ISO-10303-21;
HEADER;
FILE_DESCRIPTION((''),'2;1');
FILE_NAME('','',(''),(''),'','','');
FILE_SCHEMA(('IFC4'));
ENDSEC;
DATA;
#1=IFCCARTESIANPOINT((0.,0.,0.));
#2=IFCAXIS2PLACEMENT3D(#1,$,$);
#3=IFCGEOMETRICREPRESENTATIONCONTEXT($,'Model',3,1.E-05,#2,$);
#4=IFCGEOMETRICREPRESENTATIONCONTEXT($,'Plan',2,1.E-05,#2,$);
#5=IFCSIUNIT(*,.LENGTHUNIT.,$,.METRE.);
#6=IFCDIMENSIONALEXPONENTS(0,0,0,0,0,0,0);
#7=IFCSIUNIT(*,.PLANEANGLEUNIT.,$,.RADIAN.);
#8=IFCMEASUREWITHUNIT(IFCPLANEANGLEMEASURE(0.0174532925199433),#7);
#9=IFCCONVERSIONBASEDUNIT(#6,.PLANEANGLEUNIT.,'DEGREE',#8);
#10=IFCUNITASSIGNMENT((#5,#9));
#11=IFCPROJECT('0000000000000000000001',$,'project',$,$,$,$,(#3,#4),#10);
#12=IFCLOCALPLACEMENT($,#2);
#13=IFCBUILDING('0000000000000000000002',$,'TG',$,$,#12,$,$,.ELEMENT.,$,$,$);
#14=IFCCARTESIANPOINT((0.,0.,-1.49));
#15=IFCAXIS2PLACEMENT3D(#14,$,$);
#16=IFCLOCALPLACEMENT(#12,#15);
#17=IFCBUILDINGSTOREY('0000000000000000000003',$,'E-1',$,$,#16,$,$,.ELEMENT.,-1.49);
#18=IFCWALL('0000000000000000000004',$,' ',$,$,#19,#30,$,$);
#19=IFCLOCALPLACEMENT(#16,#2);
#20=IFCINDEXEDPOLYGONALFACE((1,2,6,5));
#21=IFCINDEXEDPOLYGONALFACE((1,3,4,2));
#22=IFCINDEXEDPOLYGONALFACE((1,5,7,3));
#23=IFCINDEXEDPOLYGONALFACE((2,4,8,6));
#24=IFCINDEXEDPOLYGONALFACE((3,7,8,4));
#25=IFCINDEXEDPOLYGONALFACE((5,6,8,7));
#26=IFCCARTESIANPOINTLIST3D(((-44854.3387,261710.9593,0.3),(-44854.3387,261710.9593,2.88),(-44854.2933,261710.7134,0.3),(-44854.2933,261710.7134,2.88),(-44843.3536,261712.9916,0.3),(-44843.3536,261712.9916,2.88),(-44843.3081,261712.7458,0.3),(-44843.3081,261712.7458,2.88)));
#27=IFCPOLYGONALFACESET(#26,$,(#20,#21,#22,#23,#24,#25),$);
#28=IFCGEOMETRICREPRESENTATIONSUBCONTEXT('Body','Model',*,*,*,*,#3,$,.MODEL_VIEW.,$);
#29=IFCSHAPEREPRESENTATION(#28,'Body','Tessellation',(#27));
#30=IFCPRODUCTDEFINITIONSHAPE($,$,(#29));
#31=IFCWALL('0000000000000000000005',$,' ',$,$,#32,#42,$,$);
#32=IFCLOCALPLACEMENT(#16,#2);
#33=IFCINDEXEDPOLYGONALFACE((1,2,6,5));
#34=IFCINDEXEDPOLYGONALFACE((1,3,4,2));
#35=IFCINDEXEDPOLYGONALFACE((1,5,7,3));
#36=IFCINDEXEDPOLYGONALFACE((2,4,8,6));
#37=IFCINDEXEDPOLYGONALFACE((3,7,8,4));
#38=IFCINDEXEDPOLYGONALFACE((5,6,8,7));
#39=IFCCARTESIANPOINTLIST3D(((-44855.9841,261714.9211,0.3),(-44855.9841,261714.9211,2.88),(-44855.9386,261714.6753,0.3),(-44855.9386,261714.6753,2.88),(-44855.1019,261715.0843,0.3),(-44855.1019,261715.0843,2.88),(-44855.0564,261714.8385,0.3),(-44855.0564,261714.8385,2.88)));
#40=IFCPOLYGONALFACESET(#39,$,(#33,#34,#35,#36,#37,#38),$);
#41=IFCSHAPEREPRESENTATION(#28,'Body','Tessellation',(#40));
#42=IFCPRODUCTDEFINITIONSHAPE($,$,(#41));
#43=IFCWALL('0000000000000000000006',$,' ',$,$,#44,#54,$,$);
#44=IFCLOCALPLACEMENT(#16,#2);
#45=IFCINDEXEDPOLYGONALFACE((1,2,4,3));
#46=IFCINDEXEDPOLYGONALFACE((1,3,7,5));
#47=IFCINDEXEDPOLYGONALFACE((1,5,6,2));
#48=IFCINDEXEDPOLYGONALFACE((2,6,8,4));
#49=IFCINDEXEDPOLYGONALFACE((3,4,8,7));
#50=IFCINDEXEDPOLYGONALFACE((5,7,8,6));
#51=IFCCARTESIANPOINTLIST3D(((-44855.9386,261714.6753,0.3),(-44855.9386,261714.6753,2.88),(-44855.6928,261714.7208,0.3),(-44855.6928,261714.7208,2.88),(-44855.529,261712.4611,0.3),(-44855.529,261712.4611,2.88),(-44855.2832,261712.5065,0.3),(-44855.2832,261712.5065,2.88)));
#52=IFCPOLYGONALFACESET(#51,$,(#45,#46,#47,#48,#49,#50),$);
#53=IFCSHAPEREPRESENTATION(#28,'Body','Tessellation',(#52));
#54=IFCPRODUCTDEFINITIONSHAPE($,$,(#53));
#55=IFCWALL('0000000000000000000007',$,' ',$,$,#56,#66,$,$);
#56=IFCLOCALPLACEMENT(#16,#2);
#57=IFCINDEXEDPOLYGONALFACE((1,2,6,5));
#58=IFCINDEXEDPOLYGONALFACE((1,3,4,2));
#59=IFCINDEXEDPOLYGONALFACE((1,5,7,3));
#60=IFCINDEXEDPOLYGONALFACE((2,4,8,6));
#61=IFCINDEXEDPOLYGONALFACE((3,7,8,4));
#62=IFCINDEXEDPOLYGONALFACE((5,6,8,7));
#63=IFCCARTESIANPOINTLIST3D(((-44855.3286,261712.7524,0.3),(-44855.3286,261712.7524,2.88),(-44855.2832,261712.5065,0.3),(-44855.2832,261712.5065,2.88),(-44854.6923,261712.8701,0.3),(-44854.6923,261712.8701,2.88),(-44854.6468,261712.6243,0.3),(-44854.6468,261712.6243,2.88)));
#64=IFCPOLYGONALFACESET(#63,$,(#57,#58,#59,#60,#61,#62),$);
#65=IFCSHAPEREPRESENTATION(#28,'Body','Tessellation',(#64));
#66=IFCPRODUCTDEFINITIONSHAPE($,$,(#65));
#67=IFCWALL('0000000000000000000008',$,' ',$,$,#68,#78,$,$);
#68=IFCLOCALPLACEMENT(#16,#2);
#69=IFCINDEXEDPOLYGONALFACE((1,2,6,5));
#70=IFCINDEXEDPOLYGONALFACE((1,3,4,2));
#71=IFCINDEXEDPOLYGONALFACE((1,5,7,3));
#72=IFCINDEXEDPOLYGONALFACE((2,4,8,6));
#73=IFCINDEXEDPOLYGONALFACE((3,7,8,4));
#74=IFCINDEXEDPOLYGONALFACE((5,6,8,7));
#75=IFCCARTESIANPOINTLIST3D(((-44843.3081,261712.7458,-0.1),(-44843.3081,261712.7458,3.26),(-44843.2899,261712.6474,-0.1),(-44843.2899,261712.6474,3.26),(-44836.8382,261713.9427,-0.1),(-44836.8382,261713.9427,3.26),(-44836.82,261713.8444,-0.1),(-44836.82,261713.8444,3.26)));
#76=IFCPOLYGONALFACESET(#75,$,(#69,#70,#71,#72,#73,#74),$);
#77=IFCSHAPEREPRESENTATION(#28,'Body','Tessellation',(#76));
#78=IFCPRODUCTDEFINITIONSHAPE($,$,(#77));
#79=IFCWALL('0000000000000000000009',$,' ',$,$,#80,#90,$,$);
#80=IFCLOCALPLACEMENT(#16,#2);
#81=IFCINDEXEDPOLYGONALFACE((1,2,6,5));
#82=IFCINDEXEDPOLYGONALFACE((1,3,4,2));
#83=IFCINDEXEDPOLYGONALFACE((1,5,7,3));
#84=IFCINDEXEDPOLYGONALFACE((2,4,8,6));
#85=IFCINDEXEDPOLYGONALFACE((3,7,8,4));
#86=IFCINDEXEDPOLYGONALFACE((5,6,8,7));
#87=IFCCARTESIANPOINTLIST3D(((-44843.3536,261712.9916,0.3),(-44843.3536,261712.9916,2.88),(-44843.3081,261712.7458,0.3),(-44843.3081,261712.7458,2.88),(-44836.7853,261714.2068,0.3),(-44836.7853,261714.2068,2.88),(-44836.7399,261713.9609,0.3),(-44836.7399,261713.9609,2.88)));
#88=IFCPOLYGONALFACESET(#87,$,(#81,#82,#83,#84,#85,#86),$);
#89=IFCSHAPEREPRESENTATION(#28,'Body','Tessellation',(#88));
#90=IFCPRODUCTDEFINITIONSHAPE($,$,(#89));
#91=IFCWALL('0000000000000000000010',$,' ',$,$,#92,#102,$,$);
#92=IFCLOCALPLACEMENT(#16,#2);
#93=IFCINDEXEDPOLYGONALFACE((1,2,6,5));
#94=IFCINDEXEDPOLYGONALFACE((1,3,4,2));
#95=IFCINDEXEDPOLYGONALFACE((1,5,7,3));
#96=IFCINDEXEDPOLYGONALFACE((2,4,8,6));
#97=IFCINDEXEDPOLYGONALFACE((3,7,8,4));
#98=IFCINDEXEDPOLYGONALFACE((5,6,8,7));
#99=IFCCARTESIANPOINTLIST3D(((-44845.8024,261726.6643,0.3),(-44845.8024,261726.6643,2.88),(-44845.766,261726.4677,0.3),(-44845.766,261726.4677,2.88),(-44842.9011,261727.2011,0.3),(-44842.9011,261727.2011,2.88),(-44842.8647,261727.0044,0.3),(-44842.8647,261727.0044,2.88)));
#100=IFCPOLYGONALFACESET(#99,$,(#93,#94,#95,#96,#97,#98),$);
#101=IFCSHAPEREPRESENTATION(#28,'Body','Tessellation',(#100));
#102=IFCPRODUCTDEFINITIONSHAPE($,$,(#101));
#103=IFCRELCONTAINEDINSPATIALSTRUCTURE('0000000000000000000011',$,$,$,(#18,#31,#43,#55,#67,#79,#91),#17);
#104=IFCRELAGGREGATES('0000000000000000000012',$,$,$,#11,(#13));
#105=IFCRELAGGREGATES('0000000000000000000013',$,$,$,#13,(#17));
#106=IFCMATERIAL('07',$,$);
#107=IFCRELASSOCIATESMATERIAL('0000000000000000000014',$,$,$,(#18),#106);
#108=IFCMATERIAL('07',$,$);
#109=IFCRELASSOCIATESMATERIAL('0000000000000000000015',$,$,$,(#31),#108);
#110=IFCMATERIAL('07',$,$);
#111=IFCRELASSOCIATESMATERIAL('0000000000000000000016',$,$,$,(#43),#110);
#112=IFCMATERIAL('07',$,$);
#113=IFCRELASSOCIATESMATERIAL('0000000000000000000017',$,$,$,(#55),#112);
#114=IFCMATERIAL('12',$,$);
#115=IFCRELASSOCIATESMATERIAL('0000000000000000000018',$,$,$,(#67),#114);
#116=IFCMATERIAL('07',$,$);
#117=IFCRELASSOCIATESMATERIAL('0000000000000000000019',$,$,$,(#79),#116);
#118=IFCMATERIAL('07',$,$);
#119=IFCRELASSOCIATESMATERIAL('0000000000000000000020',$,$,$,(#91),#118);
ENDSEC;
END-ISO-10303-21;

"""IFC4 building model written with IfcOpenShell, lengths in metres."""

from ifc_helpers import new_model, entity, si_unit, converted_unit, frame, frame_2d, origin, origin_with_axes, place, context, subcontext, project, spatial, rectangle, extrude, material, element, save


model = new_model("IFC4")

# Units and contexts
model_context = context("Model", 3, precision=1e-05, world=origin())
plan_context = context("Plan", 2, precision=1e-05, world=origin())
body_context = subcontext(model_context, "Body", "Model", "MODEL_VIEW")
ifc_project = project(units=[si_unit("LENGTHUNIT", "METRE"), converted_unit("PLANEANGLEUNIT", "DEGREE", entity("IfcPlaneAngleMeasure", 0.0174532925199433), si_unit("PLANEANGLEUNIT", "RADIAN"), dimensions=[0, 0, 0, 0, 0, 0, 0])], contexts=[model_context, plan_context])

# Building, storey
building_placement = place(None, origin())
building = spatial("IfcBuilding", under=ifc_project, at=building_placement, Name="TG", CompositionType="ELEMENT")
storey_placement = place(building_placement, frame((0.0, 0.0, -1.49)))
storey = spatial("IfcBuildingStorey", under=building, at=storey_placement, Name="E-1", CompositionType="ELEMENT", Elevation=-1.49)

# Wall
ifc_material_1 = material(Name="07")
wall_1_placement = place(storey_placement, frame((-44854.2933, 261710.7134, 0.3), z_axis=(0.0, 0.0, 1.0), x_axis=(0.983313, 0.18192, 0.0)))
element("IfcWall", 1, at=wall_1_placement, inside=storey, material=ifc_material_1, Name=" ", context=body_context, shape_type="SweptSolid", body=[
    extrude(rectangle(XDim=11.1716, YDim=0.25, at=frame_2d((5.5858, 0.125), x_axis=(1.0, 0.0))), origin_with_axes(), (0.0, 0.0, 1.0), 2.58),
])

# Walls
ifc_material_2 = material(Name="07")
wall_2_placement = place(storey_placement, frame((-44855.1019, 261715.0843, 0.3), z_axis=(0.0, 0.0, 1.0), x_axis=(-0.983313, -0.18192, 0.0)))
element("IfcWall", 2, at=wall_2_placement, inside=storey, material=ifc_material_2, Name=" ", context=body_context, shape_type="SweptSolid", body=[
    extrude(rectangle(XDim=0.8972, YDim=0.25, at=frame_2d((0.4486, 0.125), x_axis=(1.0, 0.0))), origin_with_axes(), (0.0, 0.0, 1.0), 2.58),
])
ifc_material_3 = material(Name="07")
wall_3_placement = place(storey_placement, frame((-44855.9386, 261714.6753, 0.3), z_axis=(0.0, 0.0, 1.0), x_axis=(0.18192, -0.983313, 0.0)))
element("IfcWall", 3, at=wall_3_placement, inside=storey, material=ifc_material_3, Name=" ", context=body_context, shape_type="SweptSolid", body=[
    extrude(rectangle(XDim=2.2518, YDim=0.25, at=frame_2d((1.1259, 0.125), x_axis=(1.0, 0.0))), origin_with_axes(), (0.0, 0.0, 1.0), 2.58),
])
ifc_material_4 = material(Name="07")
wall_4_placement = place(storey_placement, frame((-44855.2832, 261712.5065, 0.3), z_axis=(0.0, 0.0, 1.0), x_axis=(0.983313, 0.18192, 0.0)))
element("IfcWall", 4, at=wall_4_placement, inside=storey, material=ifc_material_4, Name=" ", context=body_context, shape_type="SweptSolid", body=[
    extrude(rectangle(XDim=0.6472, YDim=0.25, at=frame_2d((0.3236, 0.125), x_axis=(1.0, 0.0))), origin_with_axes(), (0.0, 0.0, 1.0), 2.58),
])
ifc_material_5 = material(Name="12")
wall_5_placement = place(storey_placement, frame((-44843.2899, 261712.6474, -0.1), z_axis=(0.0, 0.0, 1.0), x_axis=(0.983313, 0.18192, 0.0)))
element("IfcWall", 5, at=wall_5_placement, inside=storey, material=ifc_material_5, Name=" ", context=body_context, shape_type="SweptSolid", body=[
    extrude(rectangle(XDim=6.5797, YDim=0.1, at=frame_2d((3.2898, 0.05), x_axis=(1.0, 0.0))), origin_with_axes(), (0.0, 0.0, 1.0), 3.36),
])
ifc_material_6 = material(Name="07")
wall_6_placement = place(storey_placement, frame((-44843.3081, 261712.7458, 0.3), z_axis=(0.0, 0.0, 1.0), x_axis=(0.983313, 0.18192, 0.0)))
element("IfcWall", 6, at=wall_6_placement, inside=storey, material=ifc_material_6, Name=" ", context=body_context, shape_type="SweptSolid", body=[
    extrude(rectangle(XDim=6.6797, YDim=0.25, at=frame_2d((3.3398, 0.125), x_axis=(1.0, 0.0))), origin_with_axes(), (0.0, 0.0, 1.0), 2.58),
])
ifc_material_7 = material(Name="07")
wall_7_placement = place(storey_placement, frame((-44845.766, 261726.4677, 0.3), z_axis=(0.0, 0.0, 1.0), x_axis=(0.983313, 0.18192, 0.0)))
element("IfcWall", 7, at=wall_7_placement, inside=storey, material=ifc_material_7, Name=" ", context=body_context, shape_type="SweptSolid", body=[
    extrude(rectangle(XDim=2.9505, YDim=0.2, at=frame_2d((1.4753, 0.1), x_axis=(1.0, 0.0))), origin_with_axes(), (0.0, 0.0, 1.0), 2.58),
])

save(model, "model.ifc")
